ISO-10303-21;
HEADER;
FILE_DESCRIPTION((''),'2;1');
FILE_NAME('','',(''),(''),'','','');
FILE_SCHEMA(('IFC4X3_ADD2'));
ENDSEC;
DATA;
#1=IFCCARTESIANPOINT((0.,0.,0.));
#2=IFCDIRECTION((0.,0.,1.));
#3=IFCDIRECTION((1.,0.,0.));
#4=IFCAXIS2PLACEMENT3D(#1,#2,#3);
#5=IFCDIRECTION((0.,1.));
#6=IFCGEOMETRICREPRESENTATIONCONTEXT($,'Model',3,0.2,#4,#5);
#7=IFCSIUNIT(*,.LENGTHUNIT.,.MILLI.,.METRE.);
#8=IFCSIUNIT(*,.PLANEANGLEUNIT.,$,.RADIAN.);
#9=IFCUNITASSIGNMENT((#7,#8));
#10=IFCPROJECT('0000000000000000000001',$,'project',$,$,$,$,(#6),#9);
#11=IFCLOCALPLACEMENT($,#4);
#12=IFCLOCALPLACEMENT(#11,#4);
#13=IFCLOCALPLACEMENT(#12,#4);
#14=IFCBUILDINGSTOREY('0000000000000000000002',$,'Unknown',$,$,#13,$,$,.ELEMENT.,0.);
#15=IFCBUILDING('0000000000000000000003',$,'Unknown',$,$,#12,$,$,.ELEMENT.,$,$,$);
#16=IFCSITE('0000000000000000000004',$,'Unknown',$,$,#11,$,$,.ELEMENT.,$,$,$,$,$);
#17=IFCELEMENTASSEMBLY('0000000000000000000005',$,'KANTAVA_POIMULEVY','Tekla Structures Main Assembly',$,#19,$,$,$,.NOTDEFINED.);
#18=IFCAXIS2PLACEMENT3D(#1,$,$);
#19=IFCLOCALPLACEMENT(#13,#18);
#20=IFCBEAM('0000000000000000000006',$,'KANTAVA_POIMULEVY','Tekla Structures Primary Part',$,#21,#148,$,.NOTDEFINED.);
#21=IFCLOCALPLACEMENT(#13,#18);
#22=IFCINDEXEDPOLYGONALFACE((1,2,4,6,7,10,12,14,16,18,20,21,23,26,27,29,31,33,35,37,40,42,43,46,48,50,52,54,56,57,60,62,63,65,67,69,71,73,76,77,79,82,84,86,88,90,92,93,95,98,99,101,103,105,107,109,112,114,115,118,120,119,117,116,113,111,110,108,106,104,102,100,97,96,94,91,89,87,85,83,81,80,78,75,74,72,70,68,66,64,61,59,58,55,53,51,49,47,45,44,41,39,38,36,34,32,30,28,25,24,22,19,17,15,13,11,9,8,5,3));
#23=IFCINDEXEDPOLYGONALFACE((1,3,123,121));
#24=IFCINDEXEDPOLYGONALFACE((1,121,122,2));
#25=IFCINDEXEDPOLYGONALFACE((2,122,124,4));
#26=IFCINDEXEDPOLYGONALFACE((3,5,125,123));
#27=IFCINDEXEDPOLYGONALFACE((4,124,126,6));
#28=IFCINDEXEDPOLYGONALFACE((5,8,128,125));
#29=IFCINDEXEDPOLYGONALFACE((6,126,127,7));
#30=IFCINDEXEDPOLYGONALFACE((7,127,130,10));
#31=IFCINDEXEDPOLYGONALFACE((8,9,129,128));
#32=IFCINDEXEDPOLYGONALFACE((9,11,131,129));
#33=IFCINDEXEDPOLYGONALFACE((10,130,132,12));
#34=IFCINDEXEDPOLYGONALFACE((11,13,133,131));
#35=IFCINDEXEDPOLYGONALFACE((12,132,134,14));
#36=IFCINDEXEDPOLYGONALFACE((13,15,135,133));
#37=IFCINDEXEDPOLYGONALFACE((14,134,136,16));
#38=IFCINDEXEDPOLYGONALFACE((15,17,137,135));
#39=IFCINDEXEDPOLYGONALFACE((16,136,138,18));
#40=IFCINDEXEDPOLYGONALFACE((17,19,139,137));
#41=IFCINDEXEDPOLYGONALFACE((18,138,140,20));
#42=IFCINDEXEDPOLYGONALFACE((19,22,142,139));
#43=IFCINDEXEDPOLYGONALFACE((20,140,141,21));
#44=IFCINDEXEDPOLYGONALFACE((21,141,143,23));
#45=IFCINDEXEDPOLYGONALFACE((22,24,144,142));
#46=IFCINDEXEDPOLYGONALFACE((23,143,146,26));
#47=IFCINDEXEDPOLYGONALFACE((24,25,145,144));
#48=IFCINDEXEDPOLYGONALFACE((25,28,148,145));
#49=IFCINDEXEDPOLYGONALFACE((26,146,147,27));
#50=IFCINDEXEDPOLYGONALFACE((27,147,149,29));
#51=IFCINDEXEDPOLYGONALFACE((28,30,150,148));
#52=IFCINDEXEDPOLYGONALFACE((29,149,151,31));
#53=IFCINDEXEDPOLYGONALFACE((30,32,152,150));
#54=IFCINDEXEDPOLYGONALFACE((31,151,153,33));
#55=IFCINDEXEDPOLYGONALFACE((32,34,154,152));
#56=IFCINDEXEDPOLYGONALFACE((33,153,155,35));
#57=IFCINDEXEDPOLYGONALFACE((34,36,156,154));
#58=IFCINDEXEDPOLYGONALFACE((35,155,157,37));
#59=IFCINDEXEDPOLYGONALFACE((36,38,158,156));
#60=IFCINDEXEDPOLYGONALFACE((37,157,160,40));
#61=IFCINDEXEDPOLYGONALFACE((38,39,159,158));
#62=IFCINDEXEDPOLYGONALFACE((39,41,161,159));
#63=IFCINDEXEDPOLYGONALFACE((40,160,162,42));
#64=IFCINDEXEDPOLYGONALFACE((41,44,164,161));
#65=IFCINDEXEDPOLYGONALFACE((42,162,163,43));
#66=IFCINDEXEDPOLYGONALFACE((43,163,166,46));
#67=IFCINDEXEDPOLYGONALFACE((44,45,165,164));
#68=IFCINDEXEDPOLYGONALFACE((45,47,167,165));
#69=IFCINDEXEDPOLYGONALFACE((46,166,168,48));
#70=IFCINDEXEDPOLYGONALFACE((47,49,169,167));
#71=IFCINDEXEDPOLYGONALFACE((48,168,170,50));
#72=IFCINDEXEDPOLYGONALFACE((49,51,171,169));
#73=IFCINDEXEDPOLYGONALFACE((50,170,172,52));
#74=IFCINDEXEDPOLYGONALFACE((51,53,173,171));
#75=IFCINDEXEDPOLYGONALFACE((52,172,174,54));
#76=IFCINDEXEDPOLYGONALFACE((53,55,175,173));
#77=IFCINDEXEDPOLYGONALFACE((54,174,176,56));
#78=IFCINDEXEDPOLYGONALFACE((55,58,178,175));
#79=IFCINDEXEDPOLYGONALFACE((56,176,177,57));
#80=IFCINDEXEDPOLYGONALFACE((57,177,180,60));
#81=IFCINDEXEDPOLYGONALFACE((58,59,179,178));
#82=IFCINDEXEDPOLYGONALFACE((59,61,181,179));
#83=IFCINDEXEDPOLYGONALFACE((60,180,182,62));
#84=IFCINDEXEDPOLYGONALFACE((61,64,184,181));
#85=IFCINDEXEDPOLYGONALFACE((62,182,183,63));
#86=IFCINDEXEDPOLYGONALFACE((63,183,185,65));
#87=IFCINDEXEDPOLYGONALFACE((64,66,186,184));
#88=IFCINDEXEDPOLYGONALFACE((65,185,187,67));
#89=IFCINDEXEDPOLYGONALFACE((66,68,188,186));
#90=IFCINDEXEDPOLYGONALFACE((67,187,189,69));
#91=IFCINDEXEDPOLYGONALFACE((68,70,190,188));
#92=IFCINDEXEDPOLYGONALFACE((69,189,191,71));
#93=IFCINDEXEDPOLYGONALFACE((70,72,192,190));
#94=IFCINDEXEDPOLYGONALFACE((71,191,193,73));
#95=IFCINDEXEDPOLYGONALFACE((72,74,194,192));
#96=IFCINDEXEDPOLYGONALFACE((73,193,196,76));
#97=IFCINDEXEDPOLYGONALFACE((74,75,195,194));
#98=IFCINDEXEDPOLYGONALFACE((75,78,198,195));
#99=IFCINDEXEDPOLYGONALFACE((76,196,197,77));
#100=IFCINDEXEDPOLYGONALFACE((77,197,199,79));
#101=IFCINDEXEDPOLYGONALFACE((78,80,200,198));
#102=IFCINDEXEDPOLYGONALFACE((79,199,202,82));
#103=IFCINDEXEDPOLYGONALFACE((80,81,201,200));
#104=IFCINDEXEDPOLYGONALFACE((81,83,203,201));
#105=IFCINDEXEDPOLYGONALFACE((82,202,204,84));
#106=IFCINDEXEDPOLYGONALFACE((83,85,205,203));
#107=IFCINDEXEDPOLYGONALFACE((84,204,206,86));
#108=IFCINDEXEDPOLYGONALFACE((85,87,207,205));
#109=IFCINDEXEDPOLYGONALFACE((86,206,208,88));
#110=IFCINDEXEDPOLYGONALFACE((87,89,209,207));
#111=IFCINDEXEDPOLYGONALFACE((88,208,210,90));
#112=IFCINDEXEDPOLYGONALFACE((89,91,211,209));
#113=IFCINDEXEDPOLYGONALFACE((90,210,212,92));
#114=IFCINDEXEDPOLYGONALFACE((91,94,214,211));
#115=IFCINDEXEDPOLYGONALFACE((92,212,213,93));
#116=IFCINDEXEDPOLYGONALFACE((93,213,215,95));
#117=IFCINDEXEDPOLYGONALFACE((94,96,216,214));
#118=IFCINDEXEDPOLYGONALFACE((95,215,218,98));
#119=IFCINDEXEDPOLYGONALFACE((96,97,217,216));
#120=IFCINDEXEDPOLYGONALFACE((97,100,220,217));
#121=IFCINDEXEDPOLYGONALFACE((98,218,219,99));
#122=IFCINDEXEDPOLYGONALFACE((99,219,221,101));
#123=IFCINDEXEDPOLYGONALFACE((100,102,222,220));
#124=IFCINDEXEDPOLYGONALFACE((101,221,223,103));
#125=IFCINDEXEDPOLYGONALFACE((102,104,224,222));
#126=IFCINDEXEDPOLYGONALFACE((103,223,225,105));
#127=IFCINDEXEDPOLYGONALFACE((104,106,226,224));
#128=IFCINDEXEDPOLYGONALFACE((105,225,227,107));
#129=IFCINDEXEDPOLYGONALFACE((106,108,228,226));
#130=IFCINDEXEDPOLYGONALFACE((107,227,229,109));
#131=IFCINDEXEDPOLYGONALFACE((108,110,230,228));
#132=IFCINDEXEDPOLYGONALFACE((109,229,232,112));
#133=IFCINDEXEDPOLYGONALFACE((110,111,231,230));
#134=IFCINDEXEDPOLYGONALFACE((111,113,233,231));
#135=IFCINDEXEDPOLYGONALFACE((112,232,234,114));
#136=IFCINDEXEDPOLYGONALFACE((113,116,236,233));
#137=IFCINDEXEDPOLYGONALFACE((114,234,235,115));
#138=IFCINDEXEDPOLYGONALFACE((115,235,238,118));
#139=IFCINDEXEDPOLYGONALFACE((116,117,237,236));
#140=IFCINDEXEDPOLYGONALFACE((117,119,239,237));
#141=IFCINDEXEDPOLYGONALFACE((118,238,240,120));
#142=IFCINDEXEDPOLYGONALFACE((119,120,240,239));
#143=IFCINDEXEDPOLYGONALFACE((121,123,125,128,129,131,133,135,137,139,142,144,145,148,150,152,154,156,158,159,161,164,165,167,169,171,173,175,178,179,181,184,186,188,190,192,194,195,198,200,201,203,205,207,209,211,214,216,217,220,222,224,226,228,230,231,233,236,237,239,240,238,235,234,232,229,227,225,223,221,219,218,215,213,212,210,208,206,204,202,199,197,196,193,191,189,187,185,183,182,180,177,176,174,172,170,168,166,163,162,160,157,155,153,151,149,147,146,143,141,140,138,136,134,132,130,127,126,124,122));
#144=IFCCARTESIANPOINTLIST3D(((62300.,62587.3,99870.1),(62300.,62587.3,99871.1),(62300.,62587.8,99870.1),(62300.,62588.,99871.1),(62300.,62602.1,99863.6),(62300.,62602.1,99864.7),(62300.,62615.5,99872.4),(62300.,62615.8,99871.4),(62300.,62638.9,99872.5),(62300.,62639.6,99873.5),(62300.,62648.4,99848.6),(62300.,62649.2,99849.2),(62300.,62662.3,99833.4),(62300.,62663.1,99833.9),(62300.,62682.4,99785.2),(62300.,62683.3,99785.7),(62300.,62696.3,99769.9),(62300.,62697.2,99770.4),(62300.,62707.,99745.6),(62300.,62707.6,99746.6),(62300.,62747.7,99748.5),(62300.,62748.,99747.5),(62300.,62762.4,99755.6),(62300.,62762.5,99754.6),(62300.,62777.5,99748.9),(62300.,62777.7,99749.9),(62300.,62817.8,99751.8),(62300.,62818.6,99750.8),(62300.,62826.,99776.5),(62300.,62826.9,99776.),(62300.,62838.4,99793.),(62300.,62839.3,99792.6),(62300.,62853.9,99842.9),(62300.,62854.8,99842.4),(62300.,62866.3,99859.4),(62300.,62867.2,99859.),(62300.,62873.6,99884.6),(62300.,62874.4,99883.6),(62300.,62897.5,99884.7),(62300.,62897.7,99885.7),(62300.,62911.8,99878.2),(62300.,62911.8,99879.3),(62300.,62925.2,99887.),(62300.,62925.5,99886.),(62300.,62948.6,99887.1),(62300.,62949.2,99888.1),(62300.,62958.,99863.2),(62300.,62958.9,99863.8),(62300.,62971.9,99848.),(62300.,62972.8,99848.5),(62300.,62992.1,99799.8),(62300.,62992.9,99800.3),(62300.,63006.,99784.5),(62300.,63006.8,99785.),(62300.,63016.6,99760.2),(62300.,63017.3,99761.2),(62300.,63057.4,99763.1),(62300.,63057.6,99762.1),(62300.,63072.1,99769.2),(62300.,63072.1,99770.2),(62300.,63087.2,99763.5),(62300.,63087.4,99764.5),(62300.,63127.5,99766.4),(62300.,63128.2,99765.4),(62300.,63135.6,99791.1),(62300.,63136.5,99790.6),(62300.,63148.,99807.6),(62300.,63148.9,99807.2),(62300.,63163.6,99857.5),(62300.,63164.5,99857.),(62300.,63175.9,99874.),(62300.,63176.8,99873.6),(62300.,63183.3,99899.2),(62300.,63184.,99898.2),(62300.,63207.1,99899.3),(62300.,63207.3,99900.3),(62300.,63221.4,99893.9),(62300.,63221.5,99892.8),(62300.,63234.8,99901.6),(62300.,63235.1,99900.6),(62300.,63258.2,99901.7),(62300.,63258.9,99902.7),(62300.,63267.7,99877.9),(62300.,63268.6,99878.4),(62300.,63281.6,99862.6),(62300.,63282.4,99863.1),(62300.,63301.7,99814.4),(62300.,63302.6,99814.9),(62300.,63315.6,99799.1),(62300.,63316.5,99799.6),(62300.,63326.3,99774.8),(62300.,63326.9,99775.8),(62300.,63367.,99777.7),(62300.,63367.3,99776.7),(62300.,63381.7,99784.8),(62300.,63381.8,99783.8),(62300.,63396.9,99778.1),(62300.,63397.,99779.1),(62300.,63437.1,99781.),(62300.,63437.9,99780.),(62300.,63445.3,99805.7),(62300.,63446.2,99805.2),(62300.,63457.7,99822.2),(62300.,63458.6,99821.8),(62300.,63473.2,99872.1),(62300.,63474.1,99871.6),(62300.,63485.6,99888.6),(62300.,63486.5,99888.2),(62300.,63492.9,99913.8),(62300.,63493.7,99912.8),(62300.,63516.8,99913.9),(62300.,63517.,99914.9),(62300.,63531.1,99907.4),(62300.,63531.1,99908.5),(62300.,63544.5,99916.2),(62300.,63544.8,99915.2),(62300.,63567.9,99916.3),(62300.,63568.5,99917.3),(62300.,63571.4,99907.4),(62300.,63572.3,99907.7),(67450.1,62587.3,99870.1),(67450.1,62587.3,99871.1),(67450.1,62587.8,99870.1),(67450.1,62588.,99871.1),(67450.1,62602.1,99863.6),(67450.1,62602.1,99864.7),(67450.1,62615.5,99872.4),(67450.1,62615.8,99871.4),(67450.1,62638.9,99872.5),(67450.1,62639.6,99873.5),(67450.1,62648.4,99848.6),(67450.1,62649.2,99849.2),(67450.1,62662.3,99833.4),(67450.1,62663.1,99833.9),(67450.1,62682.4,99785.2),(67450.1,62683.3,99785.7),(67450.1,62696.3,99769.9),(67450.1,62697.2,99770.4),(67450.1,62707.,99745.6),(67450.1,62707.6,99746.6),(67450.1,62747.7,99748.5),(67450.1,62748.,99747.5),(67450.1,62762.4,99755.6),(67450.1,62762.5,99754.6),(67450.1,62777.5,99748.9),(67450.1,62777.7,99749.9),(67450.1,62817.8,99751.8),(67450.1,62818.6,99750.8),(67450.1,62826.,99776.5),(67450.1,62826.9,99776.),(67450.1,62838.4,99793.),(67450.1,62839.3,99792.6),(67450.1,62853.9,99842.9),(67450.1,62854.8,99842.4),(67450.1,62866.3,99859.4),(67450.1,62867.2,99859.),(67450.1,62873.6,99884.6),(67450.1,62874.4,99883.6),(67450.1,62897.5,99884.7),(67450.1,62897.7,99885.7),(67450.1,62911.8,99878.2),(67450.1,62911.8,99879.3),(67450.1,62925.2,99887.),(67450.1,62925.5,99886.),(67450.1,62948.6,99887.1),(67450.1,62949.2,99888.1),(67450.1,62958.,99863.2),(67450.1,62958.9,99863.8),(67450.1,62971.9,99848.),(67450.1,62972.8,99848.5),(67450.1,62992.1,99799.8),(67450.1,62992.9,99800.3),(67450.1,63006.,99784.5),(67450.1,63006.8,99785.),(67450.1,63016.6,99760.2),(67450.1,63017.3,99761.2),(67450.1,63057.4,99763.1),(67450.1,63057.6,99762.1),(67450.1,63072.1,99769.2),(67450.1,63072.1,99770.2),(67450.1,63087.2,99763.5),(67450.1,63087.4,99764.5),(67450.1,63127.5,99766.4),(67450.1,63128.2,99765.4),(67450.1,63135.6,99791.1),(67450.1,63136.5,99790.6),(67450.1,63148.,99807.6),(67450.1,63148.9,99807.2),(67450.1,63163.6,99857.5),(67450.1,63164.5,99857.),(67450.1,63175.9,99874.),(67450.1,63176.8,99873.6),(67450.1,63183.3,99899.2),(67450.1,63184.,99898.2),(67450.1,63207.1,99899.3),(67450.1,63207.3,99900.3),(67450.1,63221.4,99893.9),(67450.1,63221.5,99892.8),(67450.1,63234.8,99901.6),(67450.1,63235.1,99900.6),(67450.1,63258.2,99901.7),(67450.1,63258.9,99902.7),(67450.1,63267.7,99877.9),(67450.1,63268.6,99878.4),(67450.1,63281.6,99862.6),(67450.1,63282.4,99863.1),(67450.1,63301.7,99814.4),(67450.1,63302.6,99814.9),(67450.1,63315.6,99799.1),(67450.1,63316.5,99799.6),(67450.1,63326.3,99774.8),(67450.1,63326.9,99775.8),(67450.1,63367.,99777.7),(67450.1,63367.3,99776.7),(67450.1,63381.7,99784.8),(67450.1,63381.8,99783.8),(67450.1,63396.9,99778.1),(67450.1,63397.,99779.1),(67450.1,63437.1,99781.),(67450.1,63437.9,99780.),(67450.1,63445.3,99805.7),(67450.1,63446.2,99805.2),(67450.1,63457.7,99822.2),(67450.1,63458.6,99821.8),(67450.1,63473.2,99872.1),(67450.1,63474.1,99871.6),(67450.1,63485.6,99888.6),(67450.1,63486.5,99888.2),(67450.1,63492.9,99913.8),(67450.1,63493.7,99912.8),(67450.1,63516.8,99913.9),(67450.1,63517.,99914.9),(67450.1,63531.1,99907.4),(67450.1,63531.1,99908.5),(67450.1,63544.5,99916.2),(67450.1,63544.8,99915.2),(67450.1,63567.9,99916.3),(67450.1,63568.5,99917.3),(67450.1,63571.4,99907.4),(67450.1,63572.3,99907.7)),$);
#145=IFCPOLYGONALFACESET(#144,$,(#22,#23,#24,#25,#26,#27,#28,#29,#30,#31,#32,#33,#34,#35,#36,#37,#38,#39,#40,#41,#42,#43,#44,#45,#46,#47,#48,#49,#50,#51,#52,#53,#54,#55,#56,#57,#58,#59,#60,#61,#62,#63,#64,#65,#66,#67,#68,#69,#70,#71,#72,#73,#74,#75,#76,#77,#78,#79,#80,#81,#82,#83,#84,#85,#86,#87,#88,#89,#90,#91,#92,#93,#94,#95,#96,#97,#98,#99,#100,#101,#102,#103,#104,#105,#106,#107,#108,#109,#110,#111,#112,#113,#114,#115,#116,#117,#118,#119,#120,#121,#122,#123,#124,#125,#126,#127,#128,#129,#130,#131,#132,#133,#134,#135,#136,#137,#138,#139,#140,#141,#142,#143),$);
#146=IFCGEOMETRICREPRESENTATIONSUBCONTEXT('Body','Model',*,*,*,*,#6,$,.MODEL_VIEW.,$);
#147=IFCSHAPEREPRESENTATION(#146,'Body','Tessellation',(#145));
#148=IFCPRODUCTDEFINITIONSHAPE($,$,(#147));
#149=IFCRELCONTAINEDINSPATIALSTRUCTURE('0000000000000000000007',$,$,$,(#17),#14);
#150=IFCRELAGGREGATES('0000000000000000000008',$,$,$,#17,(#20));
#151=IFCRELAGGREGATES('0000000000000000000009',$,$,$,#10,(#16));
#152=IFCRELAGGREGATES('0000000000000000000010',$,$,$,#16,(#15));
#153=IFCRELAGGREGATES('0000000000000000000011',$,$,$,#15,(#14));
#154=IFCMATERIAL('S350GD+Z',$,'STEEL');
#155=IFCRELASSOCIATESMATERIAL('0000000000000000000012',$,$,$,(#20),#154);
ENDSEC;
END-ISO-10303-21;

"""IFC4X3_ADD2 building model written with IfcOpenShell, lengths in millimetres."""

from ifc_helpers import new_model, si_unit, direction, frame, origin_with_axes, place, context, subcontext, project, spatial, line, indexed_curve, outline, extrude, material, element, aggregate, save


model = new_model("IFC4X3_ADD2")

# Units and contexts
model_context = context("Model", 3, precision=0.2, world=origin_with_axes(), true_north=direction((0.0, 1.0)))
body_context = subcontext(model_context, "Body", "Model", "MODEL_VIEW")
ifc_project = project(units=[si_unit("LENGTHUNIT", "METRE", prefix="MILLI"), si_unit("PLANEANGLEUNIT", "RADIAN")], contexts=[model_context])

# Site, building, storey
site_placement = place(None, origin_with_axes())
site = spatial("IfcSite", under=ifc_project, at=site_placement, Name="Unknown", CompositionType="ELEMENT")
building_placement = place(site_placement, origin_with_axes())
building = spatial("IfcBuilding", under=site, at=building_placement, Name="Unknown", CompositionType="ELEMENT")
storey_placement = place(building_placement, origin_with_axes())
storey = spatial("IfcBuildingStorey", under=building, at=storey_placement, Name="Unknown", CompositionType="ELEMENT", Elevation=0.0)

# Element assembly, beam
ifc_material_1 = material(Name="S350GD+Z", Category="STEEL")
assembly_1_placement = place(storey_placement, frame((62300.0, 63069.3, 99828.2), z_axis=(0.0, -0.99889, -0.047106), x_axis=(1.0, 0.0, 0.0)))
assembly_1 = element("IfcElementAssembly", 1, at=assembly_1_placement, inside=storey, Name="KANTAVA_POIMULEVY", Description="Tekla Structures Main Assembly", PredefinedType="NOTDEFINED")
beam_1_placement = place(assembly_1_placement, origin_with_axes())
beam_1 = element("IfcBeam", 2, at=beam_1_placement, material=ifc_material_1, Name="KANTAVA_POIMULEVY", Description="Tekla Structures Primary Part", PredefinedType="NOTDEFINED", context=body_context, shape_type="SolidModel", body=[
    extrude(outline(indexed_curve([(479.5, 65.5), (478.8, 65.5), (465.0, 58.5), (451.2, 65.5), (427.1, 65.5), (418.6, 40.7), (405.5, 24.8), (387.6, -24.3), (374.5, -40.2), (365.1, -64.5), (325.0, -64.5), (310.0, -58.1), (295.0, -64.5), (254.8, -64.5), (245.5, -40.2), (232.4, -24.3), (214.5, 24.8), (201.4, 40.7), (192.9, 65.5), (168.8, 65.5), (155.0, 58.5), (141.2, 65.5), (117.1, 65.5), (108.6, 40.7), (95.5, 24.8), (77.6, -24.3), (64.5, -40.2), (55.1, -64.5), (15.0, -64.5), (0.0, -58.1), (-15.0, -64.5), (-55.2, -64.5), (-64.5, -40.2), (-77.6, -24.3), (-95.5, 24.8), (-108.6, 40.7), (-117.2, 65.5), (-141.2, 65.5), (-155.0, 58.5), (-168.8, 65.5), (-192.9, 65.5), (-201.4, 40.7), (-214.5, 24.8), (-232.4, -24.3), (-245.5, -40.2), (-254.9, -64.5), (-295.0, -64.5), (-310.0, -58.1), (-325.0, -64.5), (-365.2, -64.5), (-374.5, -40.2), (-387.6, -24.3), (-405.5, 24.8), (-418.6, 40.7), (-427.1, 65.5), (-451.2, 65.5), (-465.0, 58.5), (-478.8, 65.5), (-502.9, 65.5), (-506.2, 55.7), (-505.2, 55.4), (-502.1, 64.5), (-479.0, 64.5), (-465.0, 57.3), (-451.0, 64.5), (-427.9, 64.5), (-419.5, 40.2), (-406.4, 24.3), (-388.5, -24.8), (-375.4, -40.7), (-365.9, -65.5), (-324.8, -65.5), (-310.0, -59.1), (-295.2, -65.5), (-254.2, -65.5), (-244.6, -40.7), (-231.5, -24.8), (-213.6, 24.3), (-200.5, 40.2), (-192.1, 64.5), (-169.0, 64.5), (-155.0, 57.3), (-141.0, 64.5), (-117.9, 64.5), (-109.5, 40.2), (-96.4, 24.3), (-78.5, -24.8), (-65.4, -40.7), (-55.9, -65.5), (-14.8, -65.5), (0.0, -59.1), (14.8, -65.5), (55.8, -65.5), (65.4, -40.7), (78.5, -24.8), (96.4, 24.3), (109.5, 40.2), (117.8, 64.5), (141.0, 64.5), (155.0, 57.3), (169.0, 64.5), (192.1, 64.5), (200.5, 40.2), (213.6, 24.3), (231.5, -24.8), (244.6, -40.7), (254.1, -65.5), (295.2, -65.5), (310.0, -59.1), (324.8, -65.5), (365.8, -65.5), (375.4, -40.7), (388.5, -24.8), (406.4, 24.3), (419.5, 40.2), (427.9, 64.5), (451.0, 64.5), (465.0, 57.3), (479.0, 64.5), (479.5, 64.5)], segments=[line(1, 2, 3, 4, 5, 6, 7, 8, 9, 10, 11, 12, 13, 14, 15, 16, 17, 18, 19, 20, 21, 22, 23, 24, 25, 26, 27, 28, 29, 30, 31, 32, 33, 34, 35, 36, 37, 38, 39, 40, 41, 42, 43, 44, 45, 46, 47, 48, 49, 50, 51, 52, 53, 54, 55, 56, 57, 58, 59, 60, 61, 62, 63, 64, 65, 66, 67, 68, 69, 70, 71, 72, 73, 74, 75, 76, 77, 78, 79, 80, 81, 82, 83, 84, 85, 86, 87, 88, 89, 90, 91, 92, 93, 94, 95, 96, 97, 98, 99, 100, 101, 102, 103, 104, 105, 106, 107, 108, 109, 110, 111, 112, 113, 114, 115, 116, 117, 118, 119, 120, 1)])), frame((0.0, 0.0, 0.0), z_axis=(-1.0, 0.0, 0.0), x_axis=(0.0, 0.0, 1.0)), (0.0, 0.0, -1.0), 5150.1),
])
aggregate(assembly_1, [beam_1])

save(model, "model.ifc")
